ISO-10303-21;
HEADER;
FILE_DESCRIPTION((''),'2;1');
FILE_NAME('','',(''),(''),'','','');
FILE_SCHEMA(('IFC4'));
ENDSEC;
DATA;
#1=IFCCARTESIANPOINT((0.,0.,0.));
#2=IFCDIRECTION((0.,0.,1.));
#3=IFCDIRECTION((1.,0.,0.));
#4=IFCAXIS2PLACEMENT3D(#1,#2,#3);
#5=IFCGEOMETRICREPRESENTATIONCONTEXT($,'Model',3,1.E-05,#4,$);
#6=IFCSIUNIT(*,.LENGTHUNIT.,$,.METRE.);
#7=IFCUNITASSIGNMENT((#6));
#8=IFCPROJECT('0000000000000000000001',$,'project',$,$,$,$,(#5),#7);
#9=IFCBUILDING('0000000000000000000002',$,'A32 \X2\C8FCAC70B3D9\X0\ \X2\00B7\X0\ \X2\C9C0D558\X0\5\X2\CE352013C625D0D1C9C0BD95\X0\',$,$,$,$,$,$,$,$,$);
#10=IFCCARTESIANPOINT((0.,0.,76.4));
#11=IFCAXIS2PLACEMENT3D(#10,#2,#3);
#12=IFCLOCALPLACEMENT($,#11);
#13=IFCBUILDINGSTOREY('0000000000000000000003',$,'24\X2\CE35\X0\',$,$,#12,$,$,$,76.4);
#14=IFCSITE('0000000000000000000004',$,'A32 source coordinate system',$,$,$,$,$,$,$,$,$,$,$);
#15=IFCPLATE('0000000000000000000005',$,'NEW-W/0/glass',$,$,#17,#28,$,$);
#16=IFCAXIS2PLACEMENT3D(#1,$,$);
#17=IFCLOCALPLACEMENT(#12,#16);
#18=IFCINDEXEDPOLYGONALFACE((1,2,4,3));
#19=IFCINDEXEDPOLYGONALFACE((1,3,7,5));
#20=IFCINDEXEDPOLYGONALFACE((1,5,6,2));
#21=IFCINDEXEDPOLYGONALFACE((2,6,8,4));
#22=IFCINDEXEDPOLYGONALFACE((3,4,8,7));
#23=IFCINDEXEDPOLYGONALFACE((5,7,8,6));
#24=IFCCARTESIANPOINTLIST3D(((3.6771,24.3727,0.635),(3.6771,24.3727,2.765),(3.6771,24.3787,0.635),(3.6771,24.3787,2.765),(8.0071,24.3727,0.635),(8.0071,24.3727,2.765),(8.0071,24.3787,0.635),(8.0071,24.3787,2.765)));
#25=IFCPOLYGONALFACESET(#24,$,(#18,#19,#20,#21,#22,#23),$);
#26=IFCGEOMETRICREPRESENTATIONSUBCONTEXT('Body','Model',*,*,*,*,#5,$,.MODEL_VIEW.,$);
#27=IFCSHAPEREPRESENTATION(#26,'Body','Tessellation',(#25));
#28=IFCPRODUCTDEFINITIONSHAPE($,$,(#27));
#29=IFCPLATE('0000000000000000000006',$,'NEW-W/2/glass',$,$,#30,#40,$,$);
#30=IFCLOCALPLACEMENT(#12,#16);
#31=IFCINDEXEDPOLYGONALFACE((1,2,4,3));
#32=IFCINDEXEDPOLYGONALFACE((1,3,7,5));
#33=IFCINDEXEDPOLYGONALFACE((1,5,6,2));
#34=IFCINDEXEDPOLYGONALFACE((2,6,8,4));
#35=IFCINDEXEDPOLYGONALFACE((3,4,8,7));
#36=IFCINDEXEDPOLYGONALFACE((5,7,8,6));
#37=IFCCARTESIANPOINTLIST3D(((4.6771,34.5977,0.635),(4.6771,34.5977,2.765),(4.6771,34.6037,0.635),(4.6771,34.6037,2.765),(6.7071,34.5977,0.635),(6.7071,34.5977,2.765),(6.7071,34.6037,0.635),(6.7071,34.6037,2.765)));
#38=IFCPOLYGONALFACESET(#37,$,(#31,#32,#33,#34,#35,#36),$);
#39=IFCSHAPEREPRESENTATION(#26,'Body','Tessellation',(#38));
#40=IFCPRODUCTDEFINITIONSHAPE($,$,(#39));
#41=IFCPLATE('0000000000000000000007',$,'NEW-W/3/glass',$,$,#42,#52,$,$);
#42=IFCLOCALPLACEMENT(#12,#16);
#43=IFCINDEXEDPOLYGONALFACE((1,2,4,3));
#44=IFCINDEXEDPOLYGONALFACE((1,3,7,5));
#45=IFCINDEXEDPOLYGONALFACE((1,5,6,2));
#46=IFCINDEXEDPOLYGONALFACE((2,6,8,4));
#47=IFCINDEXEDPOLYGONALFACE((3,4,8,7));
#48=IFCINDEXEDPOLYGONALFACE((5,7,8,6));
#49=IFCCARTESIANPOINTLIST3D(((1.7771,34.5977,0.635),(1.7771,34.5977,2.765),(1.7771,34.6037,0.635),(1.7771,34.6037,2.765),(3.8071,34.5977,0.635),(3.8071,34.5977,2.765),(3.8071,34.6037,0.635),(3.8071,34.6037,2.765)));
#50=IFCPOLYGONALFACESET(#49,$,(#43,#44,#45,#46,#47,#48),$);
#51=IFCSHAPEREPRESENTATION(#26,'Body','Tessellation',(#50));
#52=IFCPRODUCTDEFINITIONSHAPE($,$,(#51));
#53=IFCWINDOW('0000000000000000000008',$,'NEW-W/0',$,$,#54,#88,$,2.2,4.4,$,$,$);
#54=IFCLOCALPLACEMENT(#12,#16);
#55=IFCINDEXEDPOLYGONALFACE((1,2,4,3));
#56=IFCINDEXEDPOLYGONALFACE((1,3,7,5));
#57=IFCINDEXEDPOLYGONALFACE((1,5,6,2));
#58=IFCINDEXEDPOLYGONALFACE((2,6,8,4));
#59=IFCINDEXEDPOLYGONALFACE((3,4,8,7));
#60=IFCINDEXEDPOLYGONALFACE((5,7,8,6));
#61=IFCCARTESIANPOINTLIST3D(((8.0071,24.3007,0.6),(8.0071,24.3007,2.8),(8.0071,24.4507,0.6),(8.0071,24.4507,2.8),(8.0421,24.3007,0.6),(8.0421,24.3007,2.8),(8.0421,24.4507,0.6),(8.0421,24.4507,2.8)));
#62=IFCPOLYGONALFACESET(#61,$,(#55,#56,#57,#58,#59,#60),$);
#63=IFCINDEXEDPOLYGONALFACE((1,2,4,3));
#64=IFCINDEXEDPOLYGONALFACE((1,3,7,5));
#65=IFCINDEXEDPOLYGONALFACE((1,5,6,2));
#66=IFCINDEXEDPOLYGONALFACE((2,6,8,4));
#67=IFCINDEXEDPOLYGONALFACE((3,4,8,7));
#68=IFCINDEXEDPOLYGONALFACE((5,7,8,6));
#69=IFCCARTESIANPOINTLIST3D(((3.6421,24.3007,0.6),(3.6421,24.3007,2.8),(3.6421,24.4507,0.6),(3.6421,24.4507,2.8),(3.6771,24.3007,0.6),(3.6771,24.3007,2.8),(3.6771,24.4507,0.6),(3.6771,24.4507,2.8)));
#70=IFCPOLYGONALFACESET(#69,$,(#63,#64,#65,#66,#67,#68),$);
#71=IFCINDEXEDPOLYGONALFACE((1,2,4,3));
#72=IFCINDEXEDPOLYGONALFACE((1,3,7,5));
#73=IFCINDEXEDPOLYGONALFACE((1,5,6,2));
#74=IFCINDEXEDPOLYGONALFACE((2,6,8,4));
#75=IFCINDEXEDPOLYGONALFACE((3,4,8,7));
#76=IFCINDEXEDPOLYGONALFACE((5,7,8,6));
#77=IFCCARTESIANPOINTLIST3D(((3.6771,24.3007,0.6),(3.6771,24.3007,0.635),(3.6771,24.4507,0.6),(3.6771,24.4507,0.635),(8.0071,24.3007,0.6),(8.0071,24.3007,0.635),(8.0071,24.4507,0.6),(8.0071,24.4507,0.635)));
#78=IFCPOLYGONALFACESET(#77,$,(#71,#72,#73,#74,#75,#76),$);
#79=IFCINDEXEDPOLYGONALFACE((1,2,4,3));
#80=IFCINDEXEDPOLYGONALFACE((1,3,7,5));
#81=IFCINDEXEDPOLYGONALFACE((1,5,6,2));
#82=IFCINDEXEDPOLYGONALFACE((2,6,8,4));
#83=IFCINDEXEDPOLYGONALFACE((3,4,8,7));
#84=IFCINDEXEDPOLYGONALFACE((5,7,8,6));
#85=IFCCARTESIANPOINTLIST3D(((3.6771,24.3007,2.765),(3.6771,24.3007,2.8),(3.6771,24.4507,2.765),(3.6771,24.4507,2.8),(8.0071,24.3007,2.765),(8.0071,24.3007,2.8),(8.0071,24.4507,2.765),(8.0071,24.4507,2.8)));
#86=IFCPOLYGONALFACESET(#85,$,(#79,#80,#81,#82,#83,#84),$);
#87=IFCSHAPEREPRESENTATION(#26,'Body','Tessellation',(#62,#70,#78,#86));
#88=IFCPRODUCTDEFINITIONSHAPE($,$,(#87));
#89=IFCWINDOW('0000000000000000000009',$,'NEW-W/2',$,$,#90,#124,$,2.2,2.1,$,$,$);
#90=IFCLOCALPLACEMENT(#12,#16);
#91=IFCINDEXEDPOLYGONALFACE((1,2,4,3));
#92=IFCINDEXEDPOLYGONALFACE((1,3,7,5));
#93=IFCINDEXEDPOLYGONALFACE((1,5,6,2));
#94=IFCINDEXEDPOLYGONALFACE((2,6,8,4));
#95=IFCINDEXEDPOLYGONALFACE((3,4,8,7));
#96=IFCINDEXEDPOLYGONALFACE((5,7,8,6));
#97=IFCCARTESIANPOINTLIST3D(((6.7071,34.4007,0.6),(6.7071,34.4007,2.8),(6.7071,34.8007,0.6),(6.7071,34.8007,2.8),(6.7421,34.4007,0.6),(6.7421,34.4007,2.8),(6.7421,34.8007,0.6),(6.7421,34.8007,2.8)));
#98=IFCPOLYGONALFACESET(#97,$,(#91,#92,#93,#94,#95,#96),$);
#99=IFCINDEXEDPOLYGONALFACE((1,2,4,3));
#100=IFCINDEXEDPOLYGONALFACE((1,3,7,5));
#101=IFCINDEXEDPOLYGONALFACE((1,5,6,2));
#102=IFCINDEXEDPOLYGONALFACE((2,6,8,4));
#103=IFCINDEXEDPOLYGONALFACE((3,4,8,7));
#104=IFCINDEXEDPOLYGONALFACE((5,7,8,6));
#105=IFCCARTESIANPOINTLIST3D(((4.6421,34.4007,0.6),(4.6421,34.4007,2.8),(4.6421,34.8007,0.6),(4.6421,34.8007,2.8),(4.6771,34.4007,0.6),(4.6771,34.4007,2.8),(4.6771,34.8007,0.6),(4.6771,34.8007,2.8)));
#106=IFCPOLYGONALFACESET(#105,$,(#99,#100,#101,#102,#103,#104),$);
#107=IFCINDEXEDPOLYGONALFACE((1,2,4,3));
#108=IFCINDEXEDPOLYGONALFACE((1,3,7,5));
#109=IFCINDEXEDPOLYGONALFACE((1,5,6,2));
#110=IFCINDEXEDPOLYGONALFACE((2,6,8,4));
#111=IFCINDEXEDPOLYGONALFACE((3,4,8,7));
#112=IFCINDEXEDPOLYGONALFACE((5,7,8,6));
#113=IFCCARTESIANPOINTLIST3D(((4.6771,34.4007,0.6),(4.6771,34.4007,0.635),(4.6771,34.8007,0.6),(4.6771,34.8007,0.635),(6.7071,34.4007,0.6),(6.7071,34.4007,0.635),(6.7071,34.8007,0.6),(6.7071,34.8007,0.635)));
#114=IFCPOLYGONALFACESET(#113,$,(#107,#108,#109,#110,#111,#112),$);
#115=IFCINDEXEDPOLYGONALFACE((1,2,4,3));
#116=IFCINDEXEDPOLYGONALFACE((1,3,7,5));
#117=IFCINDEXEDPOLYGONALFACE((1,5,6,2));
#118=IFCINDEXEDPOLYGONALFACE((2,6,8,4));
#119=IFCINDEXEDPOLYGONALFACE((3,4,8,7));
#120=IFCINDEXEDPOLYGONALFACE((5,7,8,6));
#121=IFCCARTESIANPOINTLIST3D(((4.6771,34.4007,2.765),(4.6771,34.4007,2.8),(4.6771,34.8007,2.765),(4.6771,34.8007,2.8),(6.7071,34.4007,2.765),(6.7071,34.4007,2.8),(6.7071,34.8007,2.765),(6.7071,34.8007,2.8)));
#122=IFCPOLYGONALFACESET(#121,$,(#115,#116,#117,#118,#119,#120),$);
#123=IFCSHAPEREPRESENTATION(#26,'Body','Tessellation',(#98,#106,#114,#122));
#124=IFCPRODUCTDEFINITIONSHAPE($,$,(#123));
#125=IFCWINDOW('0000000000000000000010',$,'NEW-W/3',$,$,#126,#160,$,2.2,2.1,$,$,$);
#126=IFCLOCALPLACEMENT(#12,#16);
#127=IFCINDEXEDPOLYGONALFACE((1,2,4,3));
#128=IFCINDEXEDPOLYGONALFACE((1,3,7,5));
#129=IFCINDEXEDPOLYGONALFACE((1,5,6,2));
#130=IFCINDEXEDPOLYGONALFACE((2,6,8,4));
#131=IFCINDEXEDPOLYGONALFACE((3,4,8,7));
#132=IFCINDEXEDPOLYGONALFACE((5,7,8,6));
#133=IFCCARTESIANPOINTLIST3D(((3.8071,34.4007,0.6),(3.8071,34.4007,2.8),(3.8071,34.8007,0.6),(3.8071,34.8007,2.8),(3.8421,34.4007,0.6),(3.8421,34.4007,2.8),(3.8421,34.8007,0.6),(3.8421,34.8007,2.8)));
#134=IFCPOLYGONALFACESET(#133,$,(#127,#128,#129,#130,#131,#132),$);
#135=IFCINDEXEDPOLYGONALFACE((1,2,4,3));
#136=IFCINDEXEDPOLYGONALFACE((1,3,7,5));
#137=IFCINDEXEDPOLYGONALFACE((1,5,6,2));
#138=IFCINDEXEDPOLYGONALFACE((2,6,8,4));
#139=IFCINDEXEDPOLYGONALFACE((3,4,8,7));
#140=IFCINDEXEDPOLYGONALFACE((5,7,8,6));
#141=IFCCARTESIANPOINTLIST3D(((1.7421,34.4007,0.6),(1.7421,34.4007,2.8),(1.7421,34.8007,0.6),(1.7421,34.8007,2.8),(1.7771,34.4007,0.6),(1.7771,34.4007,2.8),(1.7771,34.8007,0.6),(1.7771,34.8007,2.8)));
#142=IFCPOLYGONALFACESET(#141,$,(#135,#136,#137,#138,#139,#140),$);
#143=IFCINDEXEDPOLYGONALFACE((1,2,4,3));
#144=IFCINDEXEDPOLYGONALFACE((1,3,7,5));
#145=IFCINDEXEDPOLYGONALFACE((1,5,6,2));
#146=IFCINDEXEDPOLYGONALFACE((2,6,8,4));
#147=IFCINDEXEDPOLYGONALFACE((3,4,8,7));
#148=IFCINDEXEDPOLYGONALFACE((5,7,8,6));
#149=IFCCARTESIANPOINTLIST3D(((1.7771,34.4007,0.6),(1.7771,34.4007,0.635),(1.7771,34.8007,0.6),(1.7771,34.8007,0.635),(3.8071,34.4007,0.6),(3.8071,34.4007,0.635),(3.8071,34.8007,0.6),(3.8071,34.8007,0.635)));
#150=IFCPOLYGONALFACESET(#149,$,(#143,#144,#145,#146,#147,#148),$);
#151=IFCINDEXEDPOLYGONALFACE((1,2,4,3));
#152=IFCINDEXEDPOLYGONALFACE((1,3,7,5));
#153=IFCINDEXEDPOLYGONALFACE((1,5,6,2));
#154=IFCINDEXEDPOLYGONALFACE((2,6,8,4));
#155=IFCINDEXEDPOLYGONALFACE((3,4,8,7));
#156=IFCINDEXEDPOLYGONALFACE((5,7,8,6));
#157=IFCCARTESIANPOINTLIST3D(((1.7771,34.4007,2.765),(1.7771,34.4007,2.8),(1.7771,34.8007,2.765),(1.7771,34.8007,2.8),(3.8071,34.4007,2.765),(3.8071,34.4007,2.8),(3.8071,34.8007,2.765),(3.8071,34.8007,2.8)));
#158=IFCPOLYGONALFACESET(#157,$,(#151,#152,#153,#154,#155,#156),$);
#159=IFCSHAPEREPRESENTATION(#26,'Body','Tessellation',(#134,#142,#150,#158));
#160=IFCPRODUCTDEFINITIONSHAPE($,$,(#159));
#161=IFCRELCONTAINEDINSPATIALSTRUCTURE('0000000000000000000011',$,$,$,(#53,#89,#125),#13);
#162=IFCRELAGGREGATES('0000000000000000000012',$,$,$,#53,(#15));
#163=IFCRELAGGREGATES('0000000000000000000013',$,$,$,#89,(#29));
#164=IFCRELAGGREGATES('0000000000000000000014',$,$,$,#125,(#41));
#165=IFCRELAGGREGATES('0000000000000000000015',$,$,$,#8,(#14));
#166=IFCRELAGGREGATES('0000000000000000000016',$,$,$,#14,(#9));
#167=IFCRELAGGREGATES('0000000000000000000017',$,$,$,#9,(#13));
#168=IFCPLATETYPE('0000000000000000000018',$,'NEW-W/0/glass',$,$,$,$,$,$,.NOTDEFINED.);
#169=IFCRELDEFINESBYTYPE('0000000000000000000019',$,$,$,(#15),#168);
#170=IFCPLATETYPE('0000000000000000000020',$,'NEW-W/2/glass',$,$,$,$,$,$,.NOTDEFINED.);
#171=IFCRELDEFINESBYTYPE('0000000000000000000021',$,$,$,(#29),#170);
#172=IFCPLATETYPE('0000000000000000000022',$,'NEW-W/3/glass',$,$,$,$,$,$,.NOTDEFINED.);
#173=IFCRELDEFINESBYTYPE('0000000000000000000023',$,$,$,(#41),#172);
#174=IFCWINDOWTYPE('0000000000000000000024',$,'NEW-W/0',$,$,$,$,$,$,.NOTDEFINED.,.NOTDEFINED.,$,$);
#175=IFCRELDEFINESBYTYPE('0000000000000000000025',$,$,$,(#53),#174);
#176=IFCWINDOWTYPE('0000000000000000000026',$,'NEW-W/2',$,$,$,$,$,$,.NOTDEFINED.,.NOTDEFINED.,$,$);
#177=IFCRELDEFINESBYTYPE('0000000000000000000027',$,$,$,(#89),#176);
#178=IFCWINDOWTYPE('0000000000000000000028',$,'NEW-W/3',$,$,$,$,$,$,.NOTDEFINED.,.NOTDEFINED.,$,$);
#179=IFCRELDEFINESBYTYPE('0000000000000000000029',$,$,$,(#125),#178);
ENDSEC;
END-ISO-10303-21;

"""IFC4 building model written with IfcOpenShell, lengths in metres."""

from ifc_helpers import new_model, si_unit, frame, origin, origin_with_axes, place, context, subcontext, project, spatial, polyline, outline, extrude, source, transform, mapped, type_object, type_shapes, element, aggregate, save


model = new_model("IFC4")

# Units and contexts
model_context = context("Model", 3, precision=1e-05, world=origin_with_axes())
body_context = subcontext(model_context, "Body", "Model", "MODEL_VIEW")
ifc_project = project(units=[si_unit("LENGTHUNIT", "METRE")], contexts=[model_context])

# Site, building, storey
site = spatial("IfcSite", under=ifc_project, Name="A32 source coordinate system")
building = spatial("IfcBuilding", under=site, Name="A32 주거동 · 지하5층–옥탑지붕")
storey_placement = place(None, frame((0.0, 0.0, 76.4), z_axis=(0.0, 0.0, 1.0), x_axis=(1.0, 0.0, 0.0)))
storey = spatial("IfcBuildingStorey", under=building, at=storey_placement, Name="24층", Elevation=76.4)

# Plates
plate_type_1 = type_object("IfcPlateType", Name="NEW-W/0/glass", PredefinedType="NOTDEFINED")
shared_shape_1 = source(origin(), body_context, "Body", "SweptSolid", [
    extrude(outline(polyline([(8.0071, 24.3727), (3.6771, 24.3727), (3.6771, 24.3787), (8.0071, 24.3787), (8.0071, 24.3727)])), frame((0.0, 0.0, 0.635)), (0.0, 0.0, 1.0), 2.13),
])
type_shapes(plate_type_1, [shared_shape_1])
window_1_placement = place(storey_placement, origin_with_axes())
plate_1_placement = place(window_1_placement, origin_with_axes())
plate_1 = element("IfcPlate", 1, at=plate_1_placement, type_object=plate_type_1, Name="NEW-W/0/glass", context=body_context, shape_type="MappedRepresentation", body=[
    mapped(shared_shape_1, transform((0.0, 0.0, 0.0), scale=1.0)),
])
plate_type_2 = type_object("IfcPlateType", Name="NEW-W/2/glass", PredefinedType="NOTDEFINED")
shared_shape_2 = source(origin(), body_context, "Body", "SweptSolid", [
    extrude(outline(polyline([(6.7071, 34.5977), (4.6771, 34.5977), (4.6771, 34.6037), (6.7071, 34.6037), (6.7071, 34.5977)])), frame((0.0, 0.0, 0.635)), (0.0, 0.0, 1.0), 2.13),
])
type_shapes(plate_type_2, [shared_shape_2])
window_2_placement = place(storey_placement, origin_with_axes())
plate_2_placement = place(window_2_placement, origin_with_axes())
plate_2 = element("IfcPlate", 2, at=plate_2_placement, type_object=plate_type_2, Name="NEW-W/2/glass", context=body_context, shape_type="MappedRepresentation", body=[
    mapped(shared_shape_2, transform((0.0, 0.0, 0.0), scale=1.0)),
])
plate_type_3 = type_object("IfcPlateType", Name="NEW-W/3/glass", PredefinedType="NOTDEFINED")
shared_shape_3 = source(origin(), body_context, "Body", "SweptSolid", [
    extrude(outline(polyline([(3.8071, 34.5977), (1.7771, 34.5977), (1.7771, 34.6037), (3.8071, 34.6037), (3.8071, 34.5977)])), frame((0.0, 0.0, 0.635)), (0.0, 0.0, 1.0), 2.13),
])
type_shapes(plate_type_3, [shared_shape_3])
window_3_placement = place(storey_placement, origin_with_axes())
plate_3_placement = place(window_3_placement, origin_with_axes())
plate_3 = element("IfcPlate", 3, at=plate_3_placement, type_object=plate_type_3, Name="NEW-W/3/glass", context=body_context, shape_type="MappedRepresentation", body=[
    mapped(shared_shape_3, transform((0.0, 0.0, 0.0), scale=1.0)),
])

# Windows
window_type_1 = type_object("IfcWindowType", Name="NEW-W/0", PartitioningType="NOTDEFINED", PredefinedType="NOTDEFINED")
shared_shape_4 = source(origin(), body_context, "Body", "SweptSolid", [
    extrude(outline(polyline([(8.0071, 24.3007), (8.0071, 24.4507), (8.0421, 24.4507), (8.0421, 24.3007), (8.0071, 24.3007)])), frame((0.0, 0.0, 0.6)), (0.0, 0.0, 1.0), 2.2),
    extrude(outline(polyline([(3.6421, 24.3007), (3.6421, 24.4507), (3.6771, 24.4507), (3.6771, 24.3007), (3.6421, 24.3007)])), frame((0.0, 0.0, 0.6)), (0.0, 0.0, 1.0), 2.2),
    extrude(outline(polyline([(8.0071, 24.3007), (8.0071, 24.4507), (3.6771, 24.4507), (3.6771, 24.3007), (8.0071, 24.3007)])), frame((0.0, 0.0, 0.6)), (0.0, 0.0, 1.0), 0.035),
    extrude(outline(polyline([(8.0071, 24.3007), (8.0071, 24.4507), (3.6771, 24.4507), (3.6771, 24.3007), (8.0071, 24.3007)])), frame((0.0, 0.0, 2.765)), (0.0, 0.0, 1.0), 0.035),
])
type_shapes(window_type_1, [shared_shape_4])
window_1 = element("IfcWindow", 4, at=window_1_placement, inside=storey, type_object=window_type_1, Name="NEW-W/0", OverallHeight=2.2, OverallWidth=4.4, context=body_context, shape_type="MappedRepresentation", body=[
    mapped(shared_shape_4, transform((0.0, 0.0, 0.0), scale=1.0)),
])
aggregate(window_1, [plate_1])
window_type_2 = type_object("IfcWindowType", Name="NEW-W/2", PartitioningType="NOTDEFINED", PredefinedType="NOTDEFINED")
shared_shape_5 = source(origin(), body_context, "Body", "SweptSolid", [
    extrude(outline(polyline([(6.7071, 34.4007), (6.7071, 34.8007), (6.7421, 34.8007), (6.7421, 34.4007), (6.7071, 34.4007)])), frame((0.0, 0.0, 0.6)), (0.0, 0.0, 1.0), 2.2),
    extrude(outline(polyline([(4.6421, 34.4007), (4.6421, 34.8007), (4.6771, 34.8007), (4.6771, 34.4007), (4.6421, 34.4007)])), frame((0.0, 0.0, 0.6)), (0.0, 0.0, 1.0), 2.2),
    extrude(outline(polyline([(6.7071, 34.4007), (6.7071, 34.8007), (4.6771, 34.8007), (4.6771, 34.4007), (6.7071, 34.4007)])), frame((0.0, 0.0, 0.6)), (0.0, 0.0, 1.0), 0.035),
    extrude(outline(polyline([(6.7071, 34.4007), (6.7071, 34.8007), (4.6771, 34.8007), (4.6771, 34.4007), (6.7071, 34.4007)])), frame((0.0, 0.0, 2.765)), (0.0, 0.0, 1.0), 0.035),
])
type_shapes(window_type_2, [shared_shape_5])
window_2 = element("IfcWindow", 5, at=window_2_placement, inside=storey, type_object=window_type_2, Name="NEW-W/2", OverallHeight=2.2, OverallWidth=2.1, context=body_context, shape_type="MappedRepresentation", body=[
    mapped(shared_shape_5, transform((0.0, 0.0, 0.0), scale=1.0)),
])
aggregate(window_2, [plate_2])
window_type_3 = type_object("IfcWindowType", Name="NEW-W/3", PartitioningType="NOTDEFINED", PredefinedType="NOTDEFINED")
shared_shape_6 = source(origin(), body_context, "Body", "SweptSolid", [
    extrude(outline(polyline([(3.8071, 34.4007), (3.8071, 34.8007), (3.8421, 34.8007), (3.8421, 34.4007), (3.8071, 34.4007)])), frame((0.0, 0.0, 0.6)), (0.0, 0.0, 1.0), 2.2),
    extrude(outline(polyline([(1.7421, 34.4007), (1.7421, 34.8007), (1.7771, 34.8007), (1.7771, 34.4007), (1.7421, 34.4007)])), frame((0.0, 0.0, 0.6)), (0.0, 0.0, 1.0), 2.2),
    extrude(outline(polyline([(3.8071, 34.4007), (3.8071, 34.8007), (1.7771, 34.8007), (1.7771, 34.4007), (3.8071, 34.4007)])), frame((0.0, 0.0, 0.6)), (0.0, 0.0, 1.0), 0.035),
    extrude(outline(polyline([(3.8071, 34.4007), (3.8071, 34.8007), (1.7771, 34.8007), (1.7771, 34.4007), (3.8071, 34.4007)])), frame((0.0, 0.0, 2.765)), (0.0, 0.0, 1.0), 0.035),
])
type_shapes(window_type_3, [shared_shape_6])
window_3 = element("IfcWindow", 6, at=window_3_placement, inside=storey, type_object=window_type_3, Name="NEW-W/3", OverallHeight=2.2, OverallWidth=2.1, context=body_context, shape_type="MappedRepresentation", body=[
    mapped(shared_shape_6, transform((0.0, 0.0, 0.0), scale=1.0)),
])
aggregate(window_3, [plate_3])

save(model, "model.ifc")
